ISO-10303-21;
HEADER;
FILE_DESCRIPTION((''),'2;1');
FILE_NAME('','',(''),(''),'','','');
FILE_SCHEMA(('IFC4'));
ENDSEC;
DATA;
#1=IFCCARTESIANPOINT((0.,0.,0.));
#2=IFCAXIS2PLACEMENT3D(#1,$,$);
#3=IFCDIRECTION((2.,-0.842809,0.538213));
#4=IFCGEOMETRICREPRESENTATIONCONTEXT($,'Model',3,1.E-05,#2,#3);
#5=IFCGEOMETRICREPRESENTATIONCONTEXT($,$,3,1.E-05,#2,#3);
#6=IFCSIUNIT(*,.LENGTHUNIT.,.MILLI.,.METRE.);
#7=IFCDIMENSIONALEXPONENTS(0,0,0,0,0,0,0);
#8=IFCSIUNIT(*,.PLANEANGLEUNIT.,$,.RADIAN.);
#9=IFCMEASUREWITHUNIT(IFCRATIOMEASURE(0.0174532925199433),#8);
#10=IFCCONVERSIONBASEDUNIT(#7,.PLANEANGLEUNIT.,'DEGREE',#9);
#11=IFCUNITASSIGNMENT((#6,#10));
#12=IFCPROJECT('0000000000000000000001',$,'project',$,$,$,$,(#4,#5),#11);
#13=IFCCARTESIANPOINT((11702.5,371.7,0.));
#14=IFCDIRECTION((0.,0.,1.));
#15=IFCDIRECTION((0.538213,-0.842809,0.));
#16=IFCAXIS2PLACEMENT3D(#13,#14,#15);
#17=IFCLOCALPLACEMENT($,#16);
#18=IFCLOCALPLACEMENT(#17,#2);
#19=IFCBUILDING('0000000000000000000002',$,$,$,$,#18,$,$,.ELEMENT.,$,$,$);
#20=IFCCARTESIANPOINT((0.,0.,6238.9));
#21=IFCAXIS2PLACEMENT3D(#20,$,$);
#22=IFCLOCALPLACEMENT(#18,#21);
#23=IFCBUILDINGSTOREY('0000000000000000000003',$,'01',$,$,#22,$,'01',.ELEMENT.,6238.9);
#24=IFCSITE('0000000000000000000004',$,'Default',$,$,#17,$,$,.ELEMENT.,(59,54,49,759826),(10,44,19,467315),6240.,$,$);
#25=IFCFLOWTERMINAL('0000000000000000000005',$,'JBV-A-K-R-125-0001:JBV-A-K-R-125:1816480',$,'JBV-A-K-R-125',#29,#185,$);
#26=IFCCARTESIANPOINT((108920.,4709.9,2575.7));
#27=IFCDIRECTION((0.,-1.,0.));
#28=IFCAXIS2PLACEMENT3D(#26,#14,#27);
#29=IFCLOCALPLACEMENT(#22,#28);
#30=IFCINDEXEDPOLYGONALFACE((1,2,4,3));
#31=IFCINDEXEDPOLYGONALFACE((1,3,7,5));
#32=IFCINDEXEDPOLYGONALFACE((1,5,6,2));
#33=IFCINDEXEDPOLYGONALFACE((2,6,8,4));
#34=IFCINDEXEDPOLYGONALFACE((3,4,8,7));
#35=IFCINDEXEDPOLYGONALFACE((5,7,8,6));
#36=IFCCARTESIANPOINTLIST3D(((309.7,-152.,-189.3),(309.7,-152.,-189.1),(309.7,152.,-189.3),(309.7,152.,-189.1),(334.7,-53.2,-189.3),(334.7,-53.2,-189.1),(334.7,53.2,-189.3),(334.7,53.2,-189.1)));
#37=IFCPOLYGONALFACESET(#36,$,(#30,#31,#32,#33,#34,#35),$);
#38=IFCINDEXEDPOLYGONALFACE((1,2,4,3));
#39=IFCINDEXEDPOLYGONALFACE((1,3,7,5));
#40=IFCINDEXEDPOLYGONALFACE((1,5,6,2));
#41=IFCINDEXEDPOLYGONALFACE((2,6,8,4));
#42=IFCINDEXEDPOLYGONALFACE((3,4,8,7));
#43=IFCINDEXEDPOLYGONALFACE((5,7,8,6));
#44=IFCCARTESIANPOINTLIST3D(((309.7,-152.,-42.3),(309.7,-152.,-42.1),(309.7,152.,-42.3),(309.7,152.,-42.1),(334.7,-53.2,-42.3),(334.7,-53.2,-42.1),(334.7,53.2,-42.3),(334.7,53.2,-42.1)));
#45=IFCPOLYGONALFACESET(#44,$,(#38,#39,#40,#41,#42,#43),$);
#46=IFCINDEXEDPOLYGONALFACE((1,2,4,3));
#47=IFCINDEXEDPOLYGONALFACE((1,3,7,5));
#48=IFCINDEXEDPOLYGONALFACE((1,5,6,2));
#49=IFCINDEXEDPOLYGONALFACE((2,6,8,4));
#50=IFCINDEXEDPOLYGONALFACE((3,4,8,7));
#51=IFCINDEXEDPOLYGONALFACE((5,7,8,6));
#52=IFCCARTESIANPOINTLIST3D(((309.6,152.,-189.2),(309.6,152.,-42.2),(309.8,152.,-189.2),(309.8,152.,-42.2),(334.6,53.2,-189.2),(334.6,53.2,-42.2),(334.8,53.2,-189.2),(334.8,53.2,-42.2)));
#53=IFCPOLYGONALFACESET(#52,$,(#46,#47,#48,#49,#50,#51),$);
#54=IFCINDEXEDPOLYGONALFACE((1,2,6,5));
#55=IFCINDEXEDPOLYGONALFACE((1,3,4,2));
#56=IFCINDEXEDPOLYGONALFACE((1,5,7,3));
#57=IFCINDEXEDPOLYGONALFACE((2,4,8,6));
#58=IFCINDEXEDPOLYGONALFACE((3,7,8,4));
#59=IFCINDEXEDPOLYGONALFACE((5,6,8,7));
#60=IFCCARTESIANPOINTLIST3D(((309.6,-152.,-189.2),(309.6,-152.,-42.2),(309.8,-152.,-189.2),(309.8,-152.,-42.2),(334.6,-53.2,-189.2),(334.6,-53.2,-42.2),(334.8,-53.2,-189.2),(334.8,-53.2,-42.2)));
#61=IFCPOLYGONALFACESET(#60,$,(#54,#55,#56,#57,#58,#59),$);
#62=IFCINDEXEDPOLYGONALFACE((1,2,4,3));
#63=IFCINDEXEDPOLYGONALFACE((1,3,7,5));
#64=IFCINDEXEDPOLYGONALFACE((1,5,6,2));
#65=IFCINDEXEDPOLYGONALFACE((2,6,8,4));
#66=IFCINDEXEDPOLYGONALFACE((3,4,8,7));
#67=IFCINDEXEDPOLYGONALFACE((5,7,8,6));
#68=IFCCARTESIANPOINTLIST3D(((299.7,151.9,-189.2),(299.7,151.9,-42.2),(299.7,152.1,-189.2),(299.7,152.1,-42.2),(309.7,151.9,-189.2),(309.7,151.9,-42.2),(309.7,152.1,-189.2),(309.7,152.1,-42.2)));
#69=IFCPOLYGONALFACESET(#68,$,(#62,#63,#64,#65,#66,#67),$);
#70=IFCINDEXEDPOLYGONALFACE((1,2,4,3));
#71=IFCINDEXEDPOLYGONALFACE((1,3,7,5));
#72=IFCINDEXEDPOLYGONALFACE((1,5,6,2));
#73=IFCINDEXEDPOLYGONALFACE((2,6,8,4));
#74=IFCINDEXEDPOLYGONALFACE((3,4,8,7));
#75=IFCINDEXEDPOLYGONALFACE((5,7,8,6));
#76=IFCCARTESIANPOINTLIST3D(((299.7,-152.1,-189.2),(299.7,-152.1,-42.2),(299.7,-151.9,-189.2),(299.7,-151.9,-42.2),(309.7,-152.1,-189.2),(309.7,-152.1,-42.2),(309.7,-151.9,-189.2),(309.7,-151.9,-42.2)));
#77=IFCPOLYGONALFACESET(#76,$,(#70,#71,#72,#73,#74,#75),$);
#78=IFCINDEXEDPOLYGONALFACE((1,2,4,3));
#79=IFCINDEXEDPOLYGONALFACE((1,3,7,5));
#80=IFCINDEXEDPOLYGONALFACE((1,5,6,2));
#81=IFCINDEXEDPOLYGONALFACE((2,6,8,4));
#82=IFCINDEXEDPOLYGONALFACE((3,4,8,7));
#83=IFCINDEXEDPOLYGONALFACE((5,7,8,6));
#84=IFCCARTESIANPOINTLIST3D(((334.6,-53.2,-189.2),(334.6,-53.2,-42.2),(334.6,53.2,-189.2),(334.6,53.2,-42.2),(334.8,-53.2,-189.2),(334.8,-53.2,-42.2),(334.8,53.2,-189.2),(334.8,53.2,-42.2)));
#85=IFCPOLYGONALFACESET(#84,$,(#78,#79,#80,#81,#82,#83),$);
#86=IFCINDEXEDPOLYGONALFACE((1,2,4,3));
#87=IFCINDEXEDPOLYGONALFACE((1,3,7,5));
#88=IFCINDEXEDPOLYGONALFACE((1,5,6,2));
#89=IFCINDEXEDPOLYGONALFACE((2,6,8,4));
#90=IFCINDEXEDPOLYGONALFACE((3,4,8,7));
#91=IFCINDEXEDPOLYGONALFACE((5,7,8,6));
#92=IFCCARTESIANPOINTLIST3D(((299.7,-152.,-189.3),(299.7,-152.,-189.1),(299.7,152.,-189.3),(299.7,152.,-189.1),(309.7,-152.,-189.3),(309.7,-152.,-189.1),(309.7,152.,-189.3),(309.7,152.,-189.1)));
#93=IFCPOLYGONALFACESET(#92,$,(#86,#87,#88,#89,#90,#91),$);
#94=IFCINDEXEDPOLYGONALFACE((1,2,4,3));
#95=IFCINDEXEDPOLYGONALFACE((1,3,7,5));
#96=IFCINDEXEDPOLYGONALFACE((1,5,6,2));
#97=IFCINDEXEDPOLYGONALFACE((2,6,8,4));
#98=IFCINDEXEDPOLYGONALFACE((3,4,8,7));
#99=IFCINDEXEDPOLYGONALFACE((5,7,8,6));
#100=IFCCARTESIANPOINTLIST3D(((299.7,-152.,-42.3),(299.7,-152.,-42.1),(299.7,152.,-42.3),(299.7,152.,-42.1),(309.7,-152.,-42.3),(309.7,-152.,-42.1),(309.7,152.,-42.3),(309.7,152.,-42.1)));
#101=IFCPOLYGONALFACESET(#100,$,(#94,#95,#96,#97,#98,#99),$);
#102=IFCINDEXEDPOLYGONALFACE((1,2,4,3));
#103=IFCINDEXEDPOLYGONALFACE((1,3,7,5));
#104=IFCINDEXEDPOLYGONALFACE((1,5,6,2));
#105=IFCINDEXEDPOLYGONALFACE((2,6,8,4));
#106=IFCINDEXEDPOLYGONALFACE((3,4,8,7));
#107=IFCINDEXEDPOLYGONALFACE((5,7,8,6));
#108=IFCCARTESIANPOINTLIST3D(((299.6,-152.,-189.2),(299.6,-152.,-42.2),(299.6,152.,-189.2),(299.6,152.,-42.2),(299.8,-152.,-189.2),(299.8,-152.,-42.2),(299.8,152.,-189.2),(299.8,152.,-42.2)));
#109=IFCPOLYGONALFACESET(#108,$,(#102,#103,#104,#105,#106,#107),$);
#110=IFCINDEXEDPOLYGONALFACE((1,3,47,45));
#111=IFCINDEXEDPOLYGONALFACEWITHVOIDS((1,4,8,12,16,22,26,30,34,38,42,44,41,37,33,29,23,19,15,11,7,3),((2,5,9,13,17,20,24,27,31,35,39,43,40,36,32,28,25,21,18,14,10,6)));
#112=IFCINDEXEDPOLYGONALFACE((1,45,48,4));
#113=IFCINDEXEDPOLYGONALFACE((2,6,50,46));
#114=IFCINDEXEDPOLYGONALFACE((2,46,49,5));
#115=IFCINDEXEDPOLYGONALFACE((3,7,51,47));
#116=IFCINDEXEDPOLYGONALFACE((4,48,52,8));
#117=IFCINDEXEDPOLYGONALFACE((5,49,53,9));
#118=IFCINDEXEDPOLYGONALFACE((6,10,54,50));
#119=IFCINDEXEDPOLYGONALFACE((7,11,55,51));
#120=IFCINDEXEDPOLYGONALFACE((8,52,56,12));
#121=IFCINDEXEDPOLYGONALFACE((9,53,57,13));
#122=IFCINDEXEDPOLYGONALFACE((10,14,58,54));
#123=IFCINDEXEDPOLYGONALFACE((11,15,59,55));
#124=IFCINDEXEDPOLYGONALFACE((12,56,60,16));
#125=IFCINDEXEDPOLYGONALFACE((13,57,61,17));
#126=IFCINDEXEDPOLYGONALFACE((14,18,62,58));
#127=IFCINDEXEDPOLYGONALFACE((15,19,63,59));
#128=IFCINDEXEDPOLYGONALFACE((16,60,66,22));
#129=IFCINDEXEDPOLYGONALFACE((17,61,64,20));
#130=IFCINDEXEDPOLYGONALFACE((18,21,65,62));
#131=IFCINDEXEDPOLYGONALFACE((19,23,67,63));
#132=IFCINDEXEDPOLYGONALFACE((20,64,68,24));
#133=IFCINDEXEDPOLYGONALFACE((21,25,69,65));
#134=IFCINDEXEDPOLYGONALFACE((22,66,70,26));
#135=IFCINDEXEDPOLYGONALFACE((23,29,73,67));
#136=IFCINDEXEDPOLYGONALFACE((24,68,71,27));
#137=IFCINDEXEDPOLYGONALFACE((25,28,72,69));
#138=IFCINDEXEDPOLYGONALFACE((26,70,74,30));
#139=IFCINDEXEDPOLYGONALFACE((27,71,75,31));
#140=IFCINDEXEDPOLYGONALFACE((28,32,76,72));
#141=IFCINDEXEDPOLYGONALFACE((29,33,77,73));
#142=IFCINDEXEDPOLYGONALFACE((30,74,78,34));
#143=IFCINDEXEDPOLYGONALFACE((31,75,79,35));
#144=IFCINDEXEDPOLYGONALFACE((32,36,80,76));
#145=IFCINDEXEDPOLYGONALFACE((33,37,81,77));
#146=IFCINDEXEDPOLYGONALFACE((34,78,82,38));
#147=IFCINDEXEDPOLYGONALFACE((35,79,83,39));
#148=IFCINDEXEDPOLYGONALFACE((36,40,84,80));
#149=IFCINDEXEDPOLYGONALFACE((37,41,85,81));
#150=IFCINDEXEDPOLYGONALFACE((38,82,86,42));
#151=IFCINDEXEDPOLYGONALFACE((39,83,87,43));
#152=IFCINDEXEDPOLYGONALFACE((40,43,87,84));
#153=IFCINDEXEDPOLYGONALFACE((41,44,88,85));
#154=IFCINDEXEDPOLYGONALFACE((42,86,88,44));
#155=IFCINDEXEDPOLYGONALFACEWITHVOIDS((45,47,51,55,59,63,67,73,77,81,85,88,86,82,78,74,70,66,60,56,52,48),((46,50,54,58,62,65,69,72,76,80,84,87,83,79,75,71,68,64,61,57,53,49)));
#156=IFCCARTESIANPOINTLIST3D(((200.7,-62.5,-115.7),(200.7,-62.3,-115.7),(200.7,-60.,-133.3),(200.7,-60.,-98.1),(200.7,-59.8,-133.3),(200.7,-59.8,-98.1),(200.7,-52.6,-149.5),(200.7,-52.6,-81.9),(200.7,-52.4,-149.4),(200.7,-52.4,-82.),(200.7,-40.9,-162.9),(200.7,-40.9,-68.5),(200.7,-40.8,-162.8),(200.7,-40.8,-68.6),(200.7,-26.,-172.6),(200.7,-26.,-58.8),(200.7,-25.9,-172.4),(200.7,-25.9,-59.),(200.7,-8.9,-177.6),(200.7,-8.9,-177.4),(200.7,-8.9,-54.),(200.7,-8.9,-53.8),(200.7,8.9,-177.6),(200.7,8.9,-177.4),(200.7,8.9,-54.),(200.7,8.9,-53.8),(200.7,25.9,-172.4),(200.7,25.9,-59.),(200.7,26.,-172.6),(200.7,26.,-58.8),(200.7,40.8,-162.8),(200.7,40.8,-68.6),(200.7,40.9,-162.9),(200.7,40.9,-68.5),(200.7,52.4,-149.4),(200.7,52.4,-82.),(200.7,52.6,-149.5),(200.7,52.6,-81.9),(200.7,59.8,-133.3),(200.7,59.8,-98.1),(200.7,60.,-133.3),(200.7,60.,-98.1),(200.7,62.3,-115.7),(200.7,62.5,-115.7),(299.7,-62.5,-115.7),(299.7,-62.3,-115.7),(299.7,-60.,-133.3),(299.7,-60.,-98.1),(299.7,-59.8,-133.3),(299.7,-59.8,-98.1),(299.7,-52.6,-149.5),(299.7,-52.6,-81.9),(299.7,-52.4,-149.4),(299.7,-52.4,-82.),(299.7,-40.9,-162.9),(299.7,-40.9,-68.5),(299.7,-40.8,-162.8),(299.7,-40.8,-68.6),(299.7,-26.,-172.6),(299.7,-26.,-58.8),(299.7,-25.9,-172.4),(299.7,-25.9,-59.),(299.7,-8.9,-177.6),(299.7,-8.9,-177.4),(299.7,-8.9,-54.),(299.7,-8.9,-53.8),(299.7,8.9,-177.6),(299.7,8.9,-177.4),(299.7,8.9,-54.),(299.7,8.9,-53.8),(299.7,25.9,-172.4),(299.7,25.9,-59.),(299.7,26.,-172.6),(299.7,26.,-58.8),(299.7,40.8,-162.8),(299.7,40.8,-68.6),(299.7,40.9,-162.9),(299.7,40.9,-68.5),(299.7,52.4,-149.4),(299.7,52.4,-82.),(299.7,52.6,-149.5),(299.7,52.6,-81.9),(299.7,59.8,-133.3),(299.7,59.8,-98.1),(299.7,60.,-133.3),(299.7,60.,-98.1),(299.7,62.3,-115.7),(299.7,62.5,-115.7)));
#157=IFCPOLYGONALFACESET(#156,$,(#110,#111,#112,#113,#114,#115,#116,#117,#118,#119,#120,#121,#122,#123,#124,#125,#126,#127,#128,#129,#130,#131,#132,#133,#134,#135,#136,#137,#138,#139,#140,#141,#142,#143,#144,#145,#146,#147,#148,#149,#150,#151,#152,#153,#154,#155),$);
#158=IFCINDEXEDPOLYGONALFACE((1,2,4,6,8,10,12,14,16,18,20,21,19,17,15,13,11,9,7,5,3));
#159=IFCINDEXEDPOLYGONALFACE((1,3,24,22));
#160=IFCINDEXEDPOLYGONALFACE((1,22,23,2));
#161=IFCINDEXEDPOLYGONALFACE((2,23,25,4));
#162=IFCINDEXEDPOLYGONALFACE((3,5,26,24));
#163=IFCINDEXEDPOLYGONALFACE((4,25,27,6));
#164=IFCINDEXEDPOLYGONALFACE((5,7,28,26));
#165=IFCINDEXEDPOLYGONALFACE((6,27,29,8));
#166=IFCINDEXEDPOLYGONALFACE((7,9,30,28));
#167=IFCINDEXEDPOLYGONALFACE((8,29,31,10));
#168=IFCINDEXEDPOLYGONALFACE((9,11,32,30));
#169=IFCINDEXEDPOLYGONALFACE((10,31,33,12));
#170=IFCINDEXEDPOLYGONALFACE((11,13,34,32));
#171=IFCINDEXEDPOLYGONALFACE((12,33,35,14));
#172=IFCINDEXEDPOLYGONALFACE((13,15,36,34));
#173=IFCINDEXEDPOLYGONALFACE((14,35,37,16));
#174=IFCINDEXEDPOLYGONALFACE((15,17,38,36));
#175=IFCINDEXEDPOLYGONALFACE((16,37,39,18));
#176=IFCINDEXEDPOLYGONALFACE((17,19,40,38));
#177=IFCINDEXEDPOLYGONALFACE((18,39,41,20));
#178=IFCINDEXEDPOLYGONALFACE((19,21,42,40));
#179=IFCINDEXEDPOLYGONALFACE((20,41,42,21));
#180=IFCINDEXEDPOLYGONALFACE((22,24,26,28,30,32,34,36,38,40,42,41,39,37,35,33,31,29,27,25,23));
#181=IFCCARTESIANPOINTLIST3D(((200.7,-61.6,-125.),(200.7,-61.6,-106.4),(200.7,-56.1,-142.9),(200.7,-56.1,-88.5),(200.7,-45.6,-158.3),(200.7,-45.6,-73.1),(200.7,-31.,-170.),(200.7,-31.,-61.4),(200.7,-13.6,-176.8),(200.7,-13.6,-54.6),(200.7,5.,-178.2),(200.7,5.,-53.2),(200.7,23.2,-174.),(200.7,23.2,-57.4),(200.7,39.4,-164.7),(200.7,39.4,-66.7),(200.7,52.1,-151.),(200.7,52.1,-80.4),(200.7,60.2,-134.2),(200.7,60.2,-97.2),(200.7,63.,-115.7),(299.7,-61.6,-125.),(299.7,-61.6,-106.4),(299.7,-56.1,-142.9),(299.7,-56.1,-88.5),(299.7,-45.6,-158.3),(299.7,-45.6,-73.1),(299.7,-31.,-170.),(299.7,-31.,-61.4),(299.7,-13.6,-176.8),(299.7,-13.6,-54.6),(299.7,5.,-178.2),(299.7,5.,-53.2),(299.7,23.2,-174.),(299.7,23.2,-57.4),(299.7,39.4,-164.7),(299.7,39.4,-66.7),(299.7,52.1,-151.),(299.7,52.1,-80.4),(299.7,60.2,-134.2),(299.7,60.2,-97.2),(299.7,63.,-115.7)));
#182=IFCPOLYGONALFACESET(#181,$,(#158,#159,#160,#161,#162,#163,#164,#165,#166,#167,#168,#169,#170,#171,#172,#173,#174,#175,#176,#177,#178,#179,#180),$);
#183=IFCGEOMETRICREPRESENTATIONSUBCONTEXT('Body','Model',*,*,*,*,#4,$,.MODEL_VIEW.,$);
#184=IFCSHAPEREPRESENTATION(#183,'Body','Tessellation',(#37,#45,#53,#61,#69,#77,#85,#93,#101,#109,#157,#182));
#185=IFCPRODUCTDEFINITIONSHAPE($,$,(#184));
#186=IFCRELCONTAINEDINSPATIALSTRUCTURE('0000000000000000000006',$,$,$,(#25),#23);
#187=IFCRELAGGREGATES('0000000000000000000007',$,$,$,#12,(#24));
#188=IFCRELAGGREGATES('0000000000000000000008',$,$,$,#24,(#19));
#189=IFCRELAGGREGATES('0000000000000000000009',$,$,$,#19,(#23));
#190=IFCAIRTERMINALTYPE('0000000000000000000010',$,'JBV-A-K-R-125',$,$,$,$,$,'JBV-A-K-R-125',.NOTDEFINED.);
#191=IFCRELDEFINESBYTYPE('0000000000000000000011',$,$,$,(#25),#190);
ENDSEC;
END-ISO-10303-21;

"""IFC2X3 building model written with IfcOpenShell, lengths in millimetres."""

from ifc_helpers import new_model, entity, si_unit, converted_unit, direction, frame, frame_2d, origin, origin_2d_with_axis, place, context, subcontext, project, spatial, polyline, circle_curve, parameter, trimmed, segment, composite_curve, rectangle, circle, outline, extrude, source, transform, mapped, type_object, type_shapes, element, save


model = new_model("IFC2X3")

# Units and contexts
model_context = context("Model", 3, precision=1e-05, world=origin(), true_north=direction((2.0, -0.842809, 0.538213)))
context_of_model = context(None, 3, precision=1e-05, world=origin(), true_north=direction((2.0, -0.842809, 0.538213)))
body_context = subcontext(model_context, "Body", "Model", "MODEL_VIEW")
ifc_project = project(units=[si_unit("LENGTHUNIT", "METRE", prefix="MILLI"), converted_unit("PLANEANGLEUNIT", "DEGREE", entity("IfcRatioMeasure", 0.0174532925199433), si_unit("PLANEANGLEUNIT", "RADIAN"), dimensions=[0, 0, 0, 0, 0, 0, 0])], contexts=[model_context, context_of_model])

# Site, building, storey
site_placement = place(None, frame((11702.5, 371.7, 0.0), z_axis=(0.0, 0.0, 1.0), x_axis=(0.538213, -0.842809, 0.0)))
site = spatial("IfcSite", under=ifc_project, at=site_placement, Name="Default", CompositionType="ELEMENT", RefLatitude=(59, 54, 49, 759826), RefLongitude=(10, 44, 19, 467315), RefElevation=6240.0)
building_placement = place(site_placement, origin())
building = spatial("IfcBuilding", under=site, at=building_placement, CompositionType="ELEMENT")
storey_placement = place(building_placement, frame((0.0, 0.0, 6238.9)))
storey = spatial("IfcBuildingStorey", under=building, at=storey_placement, Name="01", LongName="01", CompositionType="ELEMENT", Elevation=6238.9)

# Flow terminal
air_terminal_type_1 = type_object("IfcAirTerminalType", Name="JBV-A-K-R-125", ElementType="JBV-A-K-R-125", PredefinedType="NOTDEFINED")
shared_shape_1 = source(origin(), body_context, "Body", "SweptSolid", [
    extrude(outline(polyline([(-152.0, -12.5), (152.0, -12.5), (53.2, 12.5), (-53.2, 12.5), (-152.0, -12.5)])), frame((322.2, 0.0, -189.3), z_axis=(0.0, 0.0, 1.0), x_axis=(0.0, -1.0, 0.0)), (0.0, 0.0, 1.0), 0.2),
    extrude(outline(polyline([(-152.0, -12.5), (152.0, -12.5), (53.2, 12.5), (-53.2, 12.5), (-152.0, -12.5)])), frame((322.2, 0.0, -42.3), z_axis=(0.0, 0.0, 1.0), x_axis=(0.0, -1.0, 0.0)), (0.0, 0.0, 1.0), 0.2),
    extrude(rectangle(XDim=0.2, YDim=101.9, at=frame_2d((0.0, 0.0), x_axis=(1.0, 0.0))), frame((322.2, 102.6, -189.2), z_axis=(0.0, 0.0, 1.0), x_axis=(0.969446, 0.245305, 0.0)), (0.0, 0.0, 1.0), 147.0),
    extrude(rectangle(XDim=0.2, YDim=101.9, at=frame_2d((0.0, 0.0), x_axis=(1.0, 0.0))), frame((322.2, -102.6, -189.2), z_axis=(0.0, 0.0, 1.0), x_axis=(-0.969446, 0.245305, 0.0)), (0.0, 0.0, 1.0), 147.0),
    extrude(rectangle(XDim=0.2, YDim=10.0, at=frame_2d((0.0, 0.0), x_axis=(1.0, 0.0))), frame((304.7, 152.0, -189.2), z_axis=(0.0, 0.0, 1.0), x_axis=(0.0, 1.0, 0.0)), (0.0, 0.0, 1.0), 147.0),
    extrude(rectangle(XDim=0.2, YDim=10.0, at=frame_2d((0.0, 0.0), x_axis=(1.0, 0.0))), frame((304.7, -152.0, -189.2), z_axis=(0.0, 0.0, 1.0), x_axis=(0.0, 1.0, 0.0)), (0.0, 0.0, 1.0), 147.0),
    extrude(rectangle(XDim=0.2, YDim=106.4, at=frame_2d((0.0, 0.0), x_axis=(1.0, 0.0))), frame((334.7, 0.0, -189.2)), (0.0, 0.0, 1.0), 147.0),
    extrude(rectangle(XDim=304.0, YDim=10.0, at=frame_2d((0.0, 0.0), x_axis=(1.0, 0.0))), frame((304.7, 0.0, -189.3), z_axis=(0.0, 0.0, 1.0), x_axis=(0.0, -1.0, 0.0)), (0.0, 0.0, 1.0), 0.2),
    extrude(rectangle(XDim=304.0, YDim=10.0, at=frame_2d((0.0, 0.0), x_axis=(1.0, 0.0))), frame((304.7, 0.0, -42.3), z_axis=(0.0, 0.0, 1.0), x_axis=(0.0, -1.0, 0.0)), (0.0, 0.0, 1.0), 0.2),
    extrude(rectangle(XDim=0.2, YDim=304.0, at=frame_2d((0.0, 0.0), x_axis=(1.0, 0.0))), frame((299.7, 0.0, -189.2)), (0.0, 0.0, 1.0), 147.0),
    extrude(outline(composite_curve([segment(trimmed(circle_curve(origin_2d_with_axis(), 62.5), [parameter(0.0)], [parameter(180.0)], True, "PARAMETER"), True, "CONTINUOUS"), segment(trimmed(circle_curve(origin_2d_with_axis(), 62.5), [parameter(180.0)], [parameter(360.0)], True, "PARAMETER"), True, "CONTINUOUS")], self_intersect=False), holes=[composite_curve([segment(trimmed(circle_curve(origin_2d_with_axis(), 62.3), [parameter(180.0)], [parameter(360.0)], True, "PARAMETER"), False, "CONTINUOUS"), segment(trimmed(circle_curve(origin_2d_with_axis(), 62.3), [parameter(0.0)], [parameter(180.0)], True, "PARAMETER"), False, "CONTINUOUS")], self_intersect=False)]), frame((200.7, 0.0, -115.7), z_axis=(1.0, 0.0, 0.0), x_axis=(0.0, 1.0, 0.0)), (0.0, 0.0, 1.0), 99.0),
    extrude(circle(Radius=62.6, at=frame_2d((0.0, 0.0), x_axis=(1.0, 0.0))), frame((200.7, 0.3, -115.7), z_axis=(1.0, 0.0, 0.0), x_axis=(0.0, 1.0, 0.0)), (0.0, 0.0, 1.0), 99.0),
])
type_shapes(air_terminal_type_1, [shared_shape_1])
for number, where, z_axis, x_axis, name in (
    (1, (108920.0, 4709.9, 2575.7), (0.0, 0.0, 1.0), (0.0, -1.0, 0.0), "JBV-A-K-R-125-0001:JBV-A-K-R-125:1816480"),
):
    element("IfcFlowTerminal", number, at=place(storey_placement, frame(where, z_axis=z_axis, x_axis=x_axis)), inside=storey, type_object=air_terminal_type_1, Name=name, ObjectType="JBV-A-K-R-125", context=body_context, shape_type="MappedRepresentation", body=[
        mapped(shared_shape_1, transform((0.0, 0.0, 0.0), scale=1.0)),
    ])

save(model, "model.ifc")
